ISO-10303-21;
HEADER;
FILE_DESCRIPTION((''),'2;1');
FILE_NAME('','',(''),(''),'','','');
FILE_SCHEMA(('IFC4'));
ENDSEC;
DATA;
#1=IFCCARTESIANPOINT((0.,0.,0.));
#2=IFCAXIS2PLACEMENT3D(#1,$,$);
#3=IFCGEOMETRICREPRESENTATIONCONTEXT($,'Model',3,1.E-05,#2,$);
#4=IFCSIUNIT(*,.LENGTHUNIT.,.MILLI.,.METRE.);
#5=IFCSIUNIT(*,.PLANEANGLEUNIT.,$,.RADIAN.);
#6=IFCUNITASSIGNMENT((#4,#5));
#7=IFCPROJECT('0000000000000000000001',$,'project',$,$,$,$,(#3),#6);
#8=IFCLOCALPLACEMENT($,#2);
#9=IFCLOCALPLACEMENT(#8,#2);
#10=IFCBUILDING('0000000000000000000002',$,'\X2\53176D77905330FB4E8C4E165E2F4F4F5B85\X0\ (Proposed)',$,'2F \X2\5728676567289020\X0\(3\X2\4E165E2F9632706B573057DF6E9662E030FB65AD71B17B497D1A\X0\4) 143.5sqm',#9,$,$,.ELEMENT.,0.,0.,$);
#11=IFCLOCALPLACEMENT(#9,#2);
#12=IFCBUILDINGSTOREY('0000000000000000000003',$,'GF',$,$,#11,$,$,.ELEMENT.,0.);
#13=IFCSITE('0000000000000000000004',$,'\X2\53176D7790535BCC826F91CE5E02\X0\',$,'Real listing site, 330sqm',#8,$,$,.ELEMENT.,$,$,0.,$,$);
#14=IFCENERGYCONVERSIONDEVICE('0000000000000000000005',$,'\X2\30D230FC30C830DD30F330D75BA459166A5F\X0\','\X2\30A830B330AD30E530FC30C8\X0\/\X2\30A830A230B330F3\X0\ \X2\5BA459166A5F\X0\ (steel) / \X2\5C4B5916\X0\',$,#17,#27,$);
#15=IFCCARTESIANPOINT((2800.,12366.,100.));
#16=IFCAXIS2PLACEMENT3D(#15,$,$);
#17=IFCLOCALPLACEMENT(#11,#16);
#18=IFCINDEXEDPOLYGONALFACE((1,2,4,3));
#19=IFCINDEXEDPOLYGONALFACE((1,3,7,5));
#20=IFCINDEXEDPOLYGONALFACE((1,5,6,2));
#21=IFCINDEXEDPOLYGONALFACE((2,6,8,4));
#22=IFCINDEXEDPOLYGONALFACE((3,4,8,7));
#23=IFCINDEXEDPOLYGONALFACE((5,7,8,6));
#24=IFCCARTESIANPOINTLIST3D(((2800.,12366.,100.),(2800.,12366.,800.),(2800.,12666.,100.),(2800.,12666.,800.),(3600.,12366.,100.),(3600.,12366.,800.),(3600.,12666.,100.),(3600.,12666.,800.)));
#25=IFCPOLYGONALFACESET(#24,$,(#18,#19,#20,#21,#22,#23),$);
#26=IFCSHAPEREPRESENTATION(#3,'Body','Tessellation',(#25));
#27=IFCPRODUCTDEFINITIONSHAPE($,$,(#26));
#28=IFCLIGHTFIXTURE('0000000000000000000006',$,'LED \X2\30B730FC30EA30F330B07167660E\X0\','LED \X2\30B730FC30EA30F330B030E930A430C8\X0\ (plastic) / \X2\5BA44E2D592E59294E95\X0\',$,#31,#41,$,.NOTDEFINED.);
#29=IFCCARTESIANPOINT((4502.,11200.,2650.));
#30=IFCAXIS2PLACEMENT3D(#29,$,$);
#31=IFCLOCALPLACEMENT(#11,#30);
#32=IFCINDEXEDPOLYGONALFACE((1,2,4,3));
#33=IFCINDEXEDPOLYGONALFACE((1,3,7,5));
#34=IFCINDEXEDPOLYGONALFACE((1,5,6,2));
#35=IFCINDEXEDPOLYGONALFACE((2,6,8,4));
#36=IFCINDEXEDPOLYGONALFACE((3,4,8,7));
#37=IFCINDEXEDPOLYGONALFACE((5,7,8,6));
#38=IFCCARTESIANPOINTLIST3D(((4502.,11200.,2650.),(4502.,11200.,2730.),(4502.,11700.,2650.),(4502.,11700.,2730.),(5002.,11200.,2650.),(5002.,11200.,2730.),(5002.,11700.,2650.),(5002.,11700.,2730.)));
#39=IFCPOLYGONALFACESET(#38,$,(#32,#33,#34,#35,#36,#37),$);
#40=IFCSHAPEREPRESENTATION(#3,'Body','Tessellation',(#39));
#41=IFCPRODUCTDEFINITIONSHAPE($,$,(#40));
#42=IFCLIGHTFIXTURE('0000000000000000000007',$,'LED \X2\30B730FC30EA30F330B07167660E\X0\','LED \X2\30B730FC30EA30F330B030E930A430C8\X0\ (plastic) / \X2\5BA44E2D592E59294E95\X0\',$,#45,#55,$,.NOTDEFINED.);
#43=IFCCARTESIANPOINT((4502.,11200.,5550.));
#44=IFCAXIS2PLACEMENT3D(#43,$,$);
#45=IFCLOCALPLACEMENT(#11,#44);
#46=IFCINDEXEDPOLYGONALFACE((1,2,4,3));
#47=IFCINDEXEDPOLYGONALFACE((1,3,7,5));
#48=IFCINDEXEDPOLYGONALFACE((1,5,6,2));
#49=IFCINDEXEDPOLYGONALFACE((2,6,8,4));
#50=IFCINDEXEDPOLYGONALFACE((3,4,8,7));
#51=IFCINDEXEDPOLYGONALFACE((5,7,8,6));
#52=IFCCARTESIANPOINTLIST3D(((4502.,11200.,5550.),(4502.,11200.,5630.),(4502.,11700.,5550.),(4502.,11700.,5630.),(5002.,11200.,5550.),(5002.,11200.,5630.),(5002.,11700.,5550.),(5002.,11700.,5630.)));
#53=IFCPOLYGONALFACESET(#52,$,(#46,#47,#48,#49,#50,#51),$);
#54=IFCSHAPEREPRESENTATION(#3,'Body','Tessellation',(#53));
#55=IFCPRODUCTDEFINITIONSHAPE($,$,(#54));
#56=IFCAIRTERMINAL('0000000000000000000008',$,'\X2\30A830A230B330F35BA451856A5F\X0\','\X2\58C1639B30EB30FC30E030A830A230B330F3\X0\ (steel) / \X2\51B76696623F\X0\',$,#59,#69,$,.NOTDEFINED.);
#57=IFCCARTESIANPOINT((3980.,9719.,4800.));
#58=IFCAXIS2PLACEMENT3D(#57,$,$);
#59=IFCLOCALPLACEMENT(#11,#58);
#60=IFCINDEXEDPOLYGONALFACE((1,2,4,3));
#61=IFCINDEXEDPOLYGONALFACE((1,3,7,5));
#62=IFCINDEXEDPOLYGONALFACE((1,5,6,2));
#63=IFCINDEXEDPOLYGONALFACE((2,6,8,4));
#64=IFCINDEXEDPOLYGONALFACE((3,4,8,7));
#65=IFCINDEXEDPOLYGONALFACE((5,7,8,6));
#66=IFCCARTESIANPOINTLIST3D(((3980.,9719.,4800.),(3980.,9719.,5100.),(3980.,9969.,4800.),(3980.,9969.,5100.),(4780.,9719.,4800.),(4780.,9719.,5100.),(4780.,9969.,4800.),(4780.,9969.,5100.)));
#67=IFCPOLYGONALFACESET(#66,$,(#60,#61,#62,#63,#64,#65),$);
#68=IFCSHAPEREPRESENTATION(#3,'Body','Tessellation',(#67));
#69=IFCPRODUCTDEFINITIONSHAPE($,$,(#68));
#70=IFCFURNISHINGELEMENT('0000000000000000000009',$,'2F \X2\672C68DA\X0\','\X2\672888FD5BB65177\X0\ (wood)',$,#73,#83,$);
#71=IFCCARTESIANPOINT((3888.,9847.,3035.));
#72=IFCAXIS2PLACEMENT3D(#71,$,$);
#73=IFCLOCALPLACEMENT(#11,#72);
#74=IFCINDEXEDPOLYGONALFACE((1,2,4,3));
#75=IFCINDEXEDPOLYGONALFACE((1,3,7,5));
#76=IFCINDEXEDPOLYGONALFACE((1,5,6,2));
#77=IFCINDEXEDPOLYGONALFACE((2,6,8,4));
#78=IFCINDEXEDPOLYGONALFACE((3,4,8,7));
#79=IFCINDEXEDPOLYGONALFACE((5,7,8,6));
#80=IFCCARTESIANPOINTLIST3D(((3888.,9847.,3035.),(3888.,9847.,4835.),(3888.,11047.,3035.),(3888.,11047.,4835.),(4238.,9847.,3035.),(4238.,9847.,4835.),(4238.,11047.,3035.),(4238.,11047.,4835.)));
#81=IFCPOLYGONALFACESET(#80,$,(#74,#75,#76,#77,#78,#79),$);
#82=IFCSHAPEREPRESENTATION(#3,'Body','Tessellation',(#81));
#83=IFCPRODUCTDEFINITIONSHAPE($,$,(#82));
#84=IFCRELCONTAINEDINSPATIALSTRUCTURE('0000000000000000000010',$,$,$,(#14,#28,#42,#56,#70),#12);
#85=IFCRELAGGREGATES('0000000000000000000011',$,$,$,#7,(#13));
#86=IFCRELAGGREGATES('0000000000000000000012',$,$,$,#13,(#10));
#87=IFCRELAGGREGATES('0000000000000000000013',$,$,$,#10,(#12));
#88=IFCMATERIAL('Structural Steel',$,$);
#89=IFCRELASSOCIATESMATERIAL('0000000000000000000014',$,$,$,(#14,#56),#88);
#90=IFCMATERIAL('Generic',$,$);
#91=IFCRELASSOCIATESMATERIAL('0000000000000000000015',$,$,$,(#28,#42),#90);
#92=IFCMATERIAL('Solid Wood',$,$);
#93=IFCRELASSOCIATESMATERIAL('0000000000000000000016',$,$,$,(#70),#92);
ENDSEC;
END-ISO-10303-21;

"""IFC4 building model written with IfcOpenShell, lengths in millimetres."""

from ifc_helpers import new_model, si_unit, frame, frame_2d, origin, place, context, project, spatial, rectangle, extrude, material, element, save


model = new_model("IFC4")

# Units and contexts
model_context = context("Model", 3, precision=1e-05, world=origin())
ifc_project = project(units=[si_unit("LENGTHUNIT", "METRE", prefix="MILLI"), si_unit("PLANEANGLEUNIT", "RADIAN")], contexts=[model_context])

# Site, building, storey
site_placement = place(None, origin())
site = spatial("IfcSite", under=ifc_project, at=site_placement, Name="北海道富良野市", ObjectType="Real listing site, 330sqm", CompositionType="ELEMENT", RefElevation=0.0)
building_placement = place(site_placement, origin())
building = spatial("IfcBuilding", under=site, at=building_placement, Name="北海道・二世帯住宅 (Proposed)", ObjectType="2F 在来木造(3世帯防火地域準拠・断熱等級4) 143.5sqm", CompositionType="ELEMENT", ElevationOfRefHeight=0.0, ElevationOfTerrain=0.0)
storey_placement = place(building_placement, origin())
storey = spatial("IfcBuildingStorey", under=building, at=storey_placement, Name="GF", CompositionType="ELEMENT", Elevation=0.0)

# Shared definitions
ifc_material_1 = material(Name="Solid Wood")

# Shared definitions
ifc_material_2 = material(Name="Structural Steel")

# Shared definitions
ifc_material_3 = material(Name="Generic")

# Energy conversion device
energy_conversion_device_placement = place(storey_placement, frame((2800.0, 12366.0, 100.0)))
element("IfcEnergyConversionDevice", 1, at=energy_conversion_device_placement, inside=storey, material=ifc_material_2, Name="ヒートポンプ室外機", Description="エコキュート/エアコン 室外機 (steel) / 屋外", context=model_context, shape_type="SweptSolid", body=[
    extrude(rectangle(XDim=800.0, YDim=300.0, at=frame_2d((400.0, 150.0))), frame((2800.0, 12366.0, 100.0)), (0.0, 0.0, 1.0), 700.0),
])

# Light fixtures
light_fixture_1_placement = place(storey_placement, frame((4502.0, 11200.0, 2650.0)))
element("IfcLightFixture", 2, at=light_fixture_1_placement, inside=storey, material=ifc_material_3, Name="LED シーリング照明", Description="LED シーリングライト (plastic) / 室中央天井", PredefinedType="NOTDEFINED", context=model_context, shape_type="SweptSolid", body=[
    extrude(rectangle(XDim=500.0, YDim=500.0, at=frame_2d((250.0, 250.0))), frame((4502.0, 11200.0, 2650.0)), (0.0, 0.0, 1.0), 80.0),
])
light_fixture_2_placement = place(storey_placement, frame((4502.0, 11200.0, 5550.0)))
element("IfcLightFixture", 3, at=light_fixture_2_placement, inside=storey, material=ifc_material_3, Name="LED シーリング照明", Description="LED シーリングライト (plastic) / 室中央天井", PredefinedType="NOTDEFINED", context=model_context, shape_type="SweptSolid", body=[
    extrude(rectangle(XDim=500.0, YDim=500.0, at=frame_2d((250.0, 250.0))), frame((4502.0, 11200.0, 5550.0)), (0.0, 0.0, 1.0), 80.0),
])

# Air terminal
air_terminal_placement = place(storey_placement, frame((3980.0, 9719.0, 4800.0)))
element("IfcAirTerminal", 4, at=air_terminal_placement, inside=storey, material=ifc_material_2, Name="エアコン室内機", Description="壁掛ルームエアコン (steel) / 冷暖房", PredefinedType="NOTDEFINED", context=model_context, shape_type="SweptSolid", body=[
    extrude(rectangle(XDim=800.0, YDim=250.0, at=frame_2d((400.0, 125.0))), frame((3980.0, 9719.0, 4800.0)), (0.0, 0.0, 1.0), 300.0),
])

# Furnishing element
furnishing_placement = place(storey_placement, frame((3888.0, 9847.0, 3035.0)))
element("IfcFurnishingElement", 5, at=furnishing_placement, inside=storey, material=ifc_material_1, Name="2F 本棚", Description="木製家具 (wood)", context=model_context, shape_type="SweptSolid", body=[
    extrude(rectangle(XDim=350.0, YDim=1200.0, at=frame_2d((175.0, 600.0))), frame((3888.0, 9847.0, 3035.0)), (0.0, 0.0, 1.0), 1800.0),
])

save(model, "model.ifc")
